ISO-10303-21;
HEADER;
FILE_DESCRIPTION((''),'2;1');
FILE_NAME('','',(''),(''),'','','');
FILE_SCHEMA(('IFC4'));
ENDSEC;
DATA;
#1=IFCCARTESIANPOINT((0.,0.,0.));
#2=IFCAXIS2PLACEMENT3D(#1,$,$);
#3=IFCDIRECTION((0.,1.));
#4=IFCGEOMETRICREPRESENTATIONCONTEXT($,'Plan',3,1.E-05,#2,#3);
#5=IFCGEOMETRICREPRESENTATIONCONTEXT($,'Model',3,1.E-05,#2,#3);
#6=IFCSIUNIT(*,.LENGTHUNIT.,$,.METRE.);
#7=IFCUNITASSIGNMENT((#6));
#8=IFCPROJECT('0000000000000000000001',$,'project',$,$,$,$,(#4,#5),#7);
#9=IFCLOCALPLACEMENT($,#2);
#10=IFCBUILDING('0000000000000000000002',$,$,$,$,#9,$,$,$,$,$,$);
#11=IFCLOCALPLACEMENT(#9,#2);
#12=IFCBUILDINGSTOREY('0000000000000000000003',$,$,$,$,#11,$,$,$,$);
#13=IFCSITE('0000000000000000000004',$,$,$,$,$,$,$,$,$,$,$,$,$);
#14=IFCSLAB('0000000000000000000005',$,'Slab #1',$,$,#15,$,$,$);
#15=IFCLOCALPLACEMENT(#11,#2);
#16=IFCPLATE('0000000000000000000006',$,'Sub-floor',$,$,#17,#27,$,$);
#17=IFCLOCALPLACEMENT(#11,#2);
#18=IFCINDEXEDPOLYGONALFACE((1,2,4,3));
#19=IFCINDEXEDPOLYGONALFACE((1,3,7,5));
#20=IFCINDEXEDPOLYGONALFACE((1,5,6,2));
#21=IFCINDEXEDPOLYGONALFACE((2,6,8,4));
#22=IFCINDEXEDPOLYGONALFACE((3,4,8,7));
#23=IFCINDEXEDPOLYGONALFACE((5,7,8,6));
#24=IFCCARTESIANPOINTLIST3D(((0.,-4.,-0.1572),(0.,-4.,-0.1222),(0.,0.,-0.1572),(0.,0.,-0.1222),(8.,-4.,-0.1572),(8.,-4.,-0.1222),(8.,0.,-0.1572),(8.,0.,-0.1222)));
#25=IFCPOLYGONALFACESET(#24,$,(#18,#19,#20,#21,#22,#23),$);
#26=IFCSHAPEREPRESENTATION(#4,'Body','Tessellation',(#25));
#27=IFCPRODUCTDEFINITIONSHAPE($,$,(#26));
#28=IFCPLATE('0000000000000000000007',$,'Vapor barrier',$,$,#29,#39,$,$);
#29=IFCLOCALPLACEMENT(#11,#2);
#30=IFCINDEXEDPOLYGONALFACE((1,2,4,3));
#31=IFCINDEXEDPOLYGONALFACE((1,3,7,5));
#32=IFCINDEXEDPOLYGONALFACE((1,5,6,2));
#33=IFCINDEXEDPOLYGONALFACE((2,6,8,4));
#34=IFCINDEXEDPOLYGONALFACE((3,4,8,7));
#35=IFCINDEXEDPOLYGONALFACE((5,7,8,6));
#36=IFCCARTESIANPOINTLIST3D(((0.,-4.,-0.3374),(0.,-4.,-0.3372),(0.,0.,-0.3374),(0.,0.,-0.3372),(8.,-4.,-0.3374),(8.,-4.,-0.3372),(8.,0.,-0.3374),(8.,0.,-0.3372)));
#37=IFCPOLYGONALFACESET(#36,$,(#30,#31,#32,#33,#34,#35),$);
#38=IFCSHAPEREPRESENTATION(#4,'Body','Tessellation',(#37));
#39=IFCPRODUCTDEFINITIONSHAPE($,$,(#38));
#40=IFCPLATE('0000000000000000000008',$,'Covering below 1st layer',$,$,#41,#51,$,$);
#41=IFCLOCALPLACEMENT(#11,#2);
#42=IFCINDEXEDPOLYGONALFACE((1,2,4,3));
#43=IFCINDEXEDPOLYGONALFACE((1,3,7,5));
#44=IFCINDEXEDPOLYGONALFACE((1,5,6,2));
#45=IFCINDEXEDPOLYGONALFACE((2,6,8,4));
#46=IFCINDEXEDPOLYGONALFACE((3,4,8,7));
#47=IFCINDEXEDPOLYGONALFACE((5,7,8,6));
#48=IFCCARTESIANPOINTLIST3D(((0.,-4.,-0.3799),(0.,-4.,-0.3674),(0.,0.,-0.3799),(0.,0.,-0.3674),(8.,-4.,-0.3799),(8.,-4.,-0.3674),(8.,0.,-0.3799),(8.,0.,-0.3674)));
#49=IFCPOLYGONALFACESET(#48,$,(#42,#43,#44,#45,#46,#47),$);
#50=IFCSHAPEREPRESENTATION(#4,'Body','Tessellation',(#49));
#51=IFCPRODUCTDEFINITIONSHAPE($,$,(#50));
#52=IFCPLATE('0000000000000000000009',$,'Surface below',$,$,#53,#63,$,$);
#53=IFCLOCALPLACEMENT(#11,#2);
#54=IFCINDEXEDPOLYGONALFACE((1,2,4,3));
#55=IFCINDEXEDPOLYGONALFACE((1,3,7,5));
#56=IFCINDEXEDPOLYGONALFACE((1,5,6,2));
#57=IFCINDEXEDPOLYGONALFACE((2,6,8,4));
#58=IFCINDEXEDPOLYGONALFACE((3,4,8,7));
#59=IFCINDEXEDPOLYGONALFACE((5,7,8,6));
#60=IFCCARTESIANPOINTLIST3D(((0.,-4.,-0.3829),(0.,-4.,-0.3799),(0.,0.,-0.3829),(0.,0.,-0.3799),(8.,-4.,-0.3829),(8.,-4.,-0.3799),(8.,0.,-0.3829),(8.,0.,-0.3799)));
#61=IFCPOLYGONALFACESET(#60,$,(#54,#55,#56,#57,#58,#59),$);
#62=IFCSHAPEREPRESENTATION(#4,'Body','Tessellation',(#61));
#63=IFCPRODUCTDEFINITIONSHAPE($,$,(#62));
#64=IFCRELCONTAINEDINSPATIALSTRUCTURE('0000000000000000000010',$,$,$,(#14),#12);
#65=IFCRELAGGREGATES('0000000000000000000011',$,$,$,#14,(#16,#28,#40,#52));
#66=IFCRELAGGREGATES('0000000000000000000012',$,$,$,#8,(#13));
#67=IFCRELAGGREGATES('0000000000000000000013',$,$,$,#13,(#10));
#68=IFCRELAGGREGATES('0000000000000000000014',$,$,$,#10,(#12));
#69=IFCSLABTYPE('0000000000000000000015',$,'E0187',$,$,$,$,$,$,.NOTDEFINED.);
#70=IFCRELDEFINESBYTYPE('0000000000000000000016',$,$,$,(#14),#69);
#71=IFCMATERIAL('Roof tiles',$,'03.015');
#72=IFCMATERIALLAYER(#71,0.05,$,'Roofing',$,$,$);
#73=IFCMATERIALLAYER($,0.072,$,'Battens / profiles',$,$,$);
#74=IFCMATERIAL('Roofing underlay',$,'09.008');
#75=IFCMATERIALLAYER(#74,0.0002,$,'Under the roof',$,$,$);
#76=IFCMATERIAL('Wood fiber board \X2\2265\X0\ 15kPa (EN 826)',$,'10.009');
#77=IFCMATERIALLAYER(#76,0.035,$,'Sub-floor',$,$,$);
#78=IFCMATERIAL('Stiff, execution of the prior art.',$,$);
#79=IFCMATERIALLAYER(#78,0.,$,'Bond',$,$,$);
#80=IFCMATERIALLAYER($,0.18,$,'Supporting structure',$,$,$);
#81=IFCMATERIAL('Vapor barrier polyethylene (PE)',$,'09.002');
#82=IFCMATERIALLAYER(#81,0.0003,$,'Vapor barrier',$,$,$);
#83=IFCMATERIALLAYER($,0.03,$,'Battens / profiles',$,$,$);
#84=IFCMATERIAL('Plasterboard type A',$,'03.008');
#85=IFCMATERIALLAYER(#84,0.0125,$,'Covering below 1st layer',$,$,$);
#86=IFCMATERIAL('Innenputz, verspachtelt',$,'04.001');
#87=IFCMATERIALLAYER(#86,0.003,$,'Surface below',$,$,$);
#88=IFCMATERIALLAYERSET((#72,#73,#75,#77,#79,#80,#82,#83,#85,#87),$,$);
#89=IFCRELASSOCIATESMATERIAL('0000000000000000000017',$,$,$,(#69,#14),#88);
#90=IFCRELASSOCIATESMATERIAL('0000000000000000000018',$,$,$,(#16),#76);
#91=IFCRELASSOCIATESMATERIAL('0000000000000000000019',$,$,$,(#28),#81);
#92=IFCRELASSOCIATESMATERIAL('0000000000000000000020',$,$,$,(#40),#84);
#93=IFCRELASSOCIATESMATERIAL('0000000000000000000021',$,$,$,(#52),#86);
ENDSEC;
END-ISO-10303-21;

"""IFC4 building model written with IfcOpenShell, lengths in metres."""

from ifc_helpers import new_model, si_unit, direction, frame, frame_2d, origin, place, context, project, spatial, rectangle, extrude, material, layer, layer_set, type_object, element, aggregate, save


model = new_model("IFC4")

# Units and contexts
plan_context = context("Plan", 3, precision=1e-05, world=origin(), true_north=direction((0.0, 1.0)))
model_context = context("Model", 3, precision=1e-05, world=origin(), true_north=direction((0.0, 1.0)))
ifc_project = project(units=[si_unit("LENGTHUNIT", "METRE")], contexts=[plan_context, model_context])

# Site, building, storey
site = spatial("IfcSite", under=ifc_project)
building_placement = place(None, origin())
building = spatial("IfcBuilding", under=site, at=building_placement)
storey_placement = place(building_placement, origin())
storey = spatial("IfcBuildingStorey", under=building, at=storey_placement)

# Slab, plates
ifc_material_1 = material(Name="Roof tiles", Category="03.015")
ifc_layer_1 = layer(ifc_material_1, 0.05, Name="Roofing")
ifc_layer_2 = layer(None, 0.072, Name="Battens / profiles")
ifc_material_2 = material(Name="Roofing underlay", Category="09.008")
ifc_layer_3 = layer(ifc_material_2, 0.0002, Name="Under the roof")
ifc_material_3 = material(Name="Wood fiber board ≥ 15kPa (EN 826)", Category="10.009")
ifc_layer_4 = layer(ifc_material_3, 0.035, Name="Sub-floor")
ifc_material_4 = material(Name="Stiff, execution of the prior art.")
ifc_layer_5 = layer(ifc_material_4, 0.0, Name="Bond")
ifc_layer_6 = layer(None, 0.18, Name="Supporting structure")
ifc_material_5 = material(Name="Vapor barrier polyethylene (PE)", Category="09.002")
ifc_layer_7 = layer(ifc_material_5, 0.0003, Name="Vapor barrier")
ifc_layer_8 = layer(None, 0.03, Name="Battens / profiles")
ifc_material_6 = material(Name="Plasterboard type A", Category="03.008")
ifc_layer_9 = layer(ifc_material_6, 0.0125, Name="Covering below 1st layer")
ifc_material_7 = material(Name="Innenputz, verspachtelt", Category="04.001")
ifc_layer_10 = layer(ifc_material_7, 0.003, Name="Surface below")
ifc_layer_set = layer_set([ifc_layer_1, ifc_layer_2, ifc_layer_3, ifc_layer_4, ifc_layer_5, ifc_layer_6, ifc_layer_7, ifc_layer_8, ifc_layer_9, ifc_layer_10])
slab_type = type_object("IfcSlabType", Name="E0187", PredefinedType="NOTDEFINED", material=ifc_layer_set)
slab_placement = place(None, frame((0.0, 0.0, 0.0), z_axis=(0.0, 0.0, -1.0), x_axis=(1.0, 0.0, 0.0)))
slab = element("IfcSlab", 1, at=slab_placement, inside=storey, type_object=slab_type, material=ifc_layer_set, Name="Slab #1")
plate_1_placement = place(slab_placement, origin())
plate_1 = element("IfcPlate", 2, at=plate_1_placement, material=ifc_material_3, Name="Sub-floor", context=plan_context, shape_type="SweptSolid", body=[
    extrude(rectangle(XDim=8.0, YDim=4.0, at=frame_2d((4.0, 2.0), x_axis=(1.0, 0.0))), frame((0.0, 0.0, 0.1222), z_axis=(0.0, 0.0, 1.0), x_axis=(1.0, 0.0, 0.0)), (0.0, 0.0, 1.0), 0.035),
])
plate_2_placement = place(slab_placement, origin())
plate_2 = element("IfcPlate", 3, at=plate_2_placement, material=ifc_material_5, Name="Vapor barrier", context=plan_context, shape_type="SweptSolid", body=[
    extrude(rectangle(XDim=8.0, YDim=4.0, at=frame_2d((4.0, 2.0), x_axis=(1.0, 0.0))), frame((0.0, 0.0, 0.3372), z_axis=(0.0, 0.0, 1.0), x_axis=(1.0, 0.0, 0.0)), (0.0, 0.0, 1.0), 0.0003),
])
plate_3_placement = place(slab_placement, origin())
plate_3 = element("IfcPlate", 4, at=plate_3_placement, material=ifc_material_6, Name="Covering below 1st layer", context=plan_context, shape_type="SweptSolid", body=[
    extrude(rectangle(XDim=8.0, YDim=4.0, at=frame_2d((4.0, 2.0), x_axis=(1.0, 0.0))), frame((0.0, 0.0, 0.3674), z_axis=(0.0, 0.0, 1.0), x_axis=(1.0, 0.0, 0.0)), (0.0, 0.0, 1.0), 0.0125),
])
plate_4_placement = place(slab_placement, origin())
plate_4 = element("IfcPlate", 5, at=plate_4_placement, material=ifc_material_7, Name="Surface below", context=plan_context, shape_type="SweptSolid", body=[
    extrude(rectangle(XDim=8.0, YDim=4.0, at=frame_2d((4.0, 2.0), x_axis=(1.0, 0.0))), frame((0.0, 0.0, 0.3799), z_axis=(0.0, 0.0, 1.0), x_axis=(1.0, 0.0, 0.0)), (0.0, 0.0, 1.0), 0.003),
])
aggregate(slab, [plate_1, plate_2, plate_3, plate_4])

save(model, "model.ifc")
